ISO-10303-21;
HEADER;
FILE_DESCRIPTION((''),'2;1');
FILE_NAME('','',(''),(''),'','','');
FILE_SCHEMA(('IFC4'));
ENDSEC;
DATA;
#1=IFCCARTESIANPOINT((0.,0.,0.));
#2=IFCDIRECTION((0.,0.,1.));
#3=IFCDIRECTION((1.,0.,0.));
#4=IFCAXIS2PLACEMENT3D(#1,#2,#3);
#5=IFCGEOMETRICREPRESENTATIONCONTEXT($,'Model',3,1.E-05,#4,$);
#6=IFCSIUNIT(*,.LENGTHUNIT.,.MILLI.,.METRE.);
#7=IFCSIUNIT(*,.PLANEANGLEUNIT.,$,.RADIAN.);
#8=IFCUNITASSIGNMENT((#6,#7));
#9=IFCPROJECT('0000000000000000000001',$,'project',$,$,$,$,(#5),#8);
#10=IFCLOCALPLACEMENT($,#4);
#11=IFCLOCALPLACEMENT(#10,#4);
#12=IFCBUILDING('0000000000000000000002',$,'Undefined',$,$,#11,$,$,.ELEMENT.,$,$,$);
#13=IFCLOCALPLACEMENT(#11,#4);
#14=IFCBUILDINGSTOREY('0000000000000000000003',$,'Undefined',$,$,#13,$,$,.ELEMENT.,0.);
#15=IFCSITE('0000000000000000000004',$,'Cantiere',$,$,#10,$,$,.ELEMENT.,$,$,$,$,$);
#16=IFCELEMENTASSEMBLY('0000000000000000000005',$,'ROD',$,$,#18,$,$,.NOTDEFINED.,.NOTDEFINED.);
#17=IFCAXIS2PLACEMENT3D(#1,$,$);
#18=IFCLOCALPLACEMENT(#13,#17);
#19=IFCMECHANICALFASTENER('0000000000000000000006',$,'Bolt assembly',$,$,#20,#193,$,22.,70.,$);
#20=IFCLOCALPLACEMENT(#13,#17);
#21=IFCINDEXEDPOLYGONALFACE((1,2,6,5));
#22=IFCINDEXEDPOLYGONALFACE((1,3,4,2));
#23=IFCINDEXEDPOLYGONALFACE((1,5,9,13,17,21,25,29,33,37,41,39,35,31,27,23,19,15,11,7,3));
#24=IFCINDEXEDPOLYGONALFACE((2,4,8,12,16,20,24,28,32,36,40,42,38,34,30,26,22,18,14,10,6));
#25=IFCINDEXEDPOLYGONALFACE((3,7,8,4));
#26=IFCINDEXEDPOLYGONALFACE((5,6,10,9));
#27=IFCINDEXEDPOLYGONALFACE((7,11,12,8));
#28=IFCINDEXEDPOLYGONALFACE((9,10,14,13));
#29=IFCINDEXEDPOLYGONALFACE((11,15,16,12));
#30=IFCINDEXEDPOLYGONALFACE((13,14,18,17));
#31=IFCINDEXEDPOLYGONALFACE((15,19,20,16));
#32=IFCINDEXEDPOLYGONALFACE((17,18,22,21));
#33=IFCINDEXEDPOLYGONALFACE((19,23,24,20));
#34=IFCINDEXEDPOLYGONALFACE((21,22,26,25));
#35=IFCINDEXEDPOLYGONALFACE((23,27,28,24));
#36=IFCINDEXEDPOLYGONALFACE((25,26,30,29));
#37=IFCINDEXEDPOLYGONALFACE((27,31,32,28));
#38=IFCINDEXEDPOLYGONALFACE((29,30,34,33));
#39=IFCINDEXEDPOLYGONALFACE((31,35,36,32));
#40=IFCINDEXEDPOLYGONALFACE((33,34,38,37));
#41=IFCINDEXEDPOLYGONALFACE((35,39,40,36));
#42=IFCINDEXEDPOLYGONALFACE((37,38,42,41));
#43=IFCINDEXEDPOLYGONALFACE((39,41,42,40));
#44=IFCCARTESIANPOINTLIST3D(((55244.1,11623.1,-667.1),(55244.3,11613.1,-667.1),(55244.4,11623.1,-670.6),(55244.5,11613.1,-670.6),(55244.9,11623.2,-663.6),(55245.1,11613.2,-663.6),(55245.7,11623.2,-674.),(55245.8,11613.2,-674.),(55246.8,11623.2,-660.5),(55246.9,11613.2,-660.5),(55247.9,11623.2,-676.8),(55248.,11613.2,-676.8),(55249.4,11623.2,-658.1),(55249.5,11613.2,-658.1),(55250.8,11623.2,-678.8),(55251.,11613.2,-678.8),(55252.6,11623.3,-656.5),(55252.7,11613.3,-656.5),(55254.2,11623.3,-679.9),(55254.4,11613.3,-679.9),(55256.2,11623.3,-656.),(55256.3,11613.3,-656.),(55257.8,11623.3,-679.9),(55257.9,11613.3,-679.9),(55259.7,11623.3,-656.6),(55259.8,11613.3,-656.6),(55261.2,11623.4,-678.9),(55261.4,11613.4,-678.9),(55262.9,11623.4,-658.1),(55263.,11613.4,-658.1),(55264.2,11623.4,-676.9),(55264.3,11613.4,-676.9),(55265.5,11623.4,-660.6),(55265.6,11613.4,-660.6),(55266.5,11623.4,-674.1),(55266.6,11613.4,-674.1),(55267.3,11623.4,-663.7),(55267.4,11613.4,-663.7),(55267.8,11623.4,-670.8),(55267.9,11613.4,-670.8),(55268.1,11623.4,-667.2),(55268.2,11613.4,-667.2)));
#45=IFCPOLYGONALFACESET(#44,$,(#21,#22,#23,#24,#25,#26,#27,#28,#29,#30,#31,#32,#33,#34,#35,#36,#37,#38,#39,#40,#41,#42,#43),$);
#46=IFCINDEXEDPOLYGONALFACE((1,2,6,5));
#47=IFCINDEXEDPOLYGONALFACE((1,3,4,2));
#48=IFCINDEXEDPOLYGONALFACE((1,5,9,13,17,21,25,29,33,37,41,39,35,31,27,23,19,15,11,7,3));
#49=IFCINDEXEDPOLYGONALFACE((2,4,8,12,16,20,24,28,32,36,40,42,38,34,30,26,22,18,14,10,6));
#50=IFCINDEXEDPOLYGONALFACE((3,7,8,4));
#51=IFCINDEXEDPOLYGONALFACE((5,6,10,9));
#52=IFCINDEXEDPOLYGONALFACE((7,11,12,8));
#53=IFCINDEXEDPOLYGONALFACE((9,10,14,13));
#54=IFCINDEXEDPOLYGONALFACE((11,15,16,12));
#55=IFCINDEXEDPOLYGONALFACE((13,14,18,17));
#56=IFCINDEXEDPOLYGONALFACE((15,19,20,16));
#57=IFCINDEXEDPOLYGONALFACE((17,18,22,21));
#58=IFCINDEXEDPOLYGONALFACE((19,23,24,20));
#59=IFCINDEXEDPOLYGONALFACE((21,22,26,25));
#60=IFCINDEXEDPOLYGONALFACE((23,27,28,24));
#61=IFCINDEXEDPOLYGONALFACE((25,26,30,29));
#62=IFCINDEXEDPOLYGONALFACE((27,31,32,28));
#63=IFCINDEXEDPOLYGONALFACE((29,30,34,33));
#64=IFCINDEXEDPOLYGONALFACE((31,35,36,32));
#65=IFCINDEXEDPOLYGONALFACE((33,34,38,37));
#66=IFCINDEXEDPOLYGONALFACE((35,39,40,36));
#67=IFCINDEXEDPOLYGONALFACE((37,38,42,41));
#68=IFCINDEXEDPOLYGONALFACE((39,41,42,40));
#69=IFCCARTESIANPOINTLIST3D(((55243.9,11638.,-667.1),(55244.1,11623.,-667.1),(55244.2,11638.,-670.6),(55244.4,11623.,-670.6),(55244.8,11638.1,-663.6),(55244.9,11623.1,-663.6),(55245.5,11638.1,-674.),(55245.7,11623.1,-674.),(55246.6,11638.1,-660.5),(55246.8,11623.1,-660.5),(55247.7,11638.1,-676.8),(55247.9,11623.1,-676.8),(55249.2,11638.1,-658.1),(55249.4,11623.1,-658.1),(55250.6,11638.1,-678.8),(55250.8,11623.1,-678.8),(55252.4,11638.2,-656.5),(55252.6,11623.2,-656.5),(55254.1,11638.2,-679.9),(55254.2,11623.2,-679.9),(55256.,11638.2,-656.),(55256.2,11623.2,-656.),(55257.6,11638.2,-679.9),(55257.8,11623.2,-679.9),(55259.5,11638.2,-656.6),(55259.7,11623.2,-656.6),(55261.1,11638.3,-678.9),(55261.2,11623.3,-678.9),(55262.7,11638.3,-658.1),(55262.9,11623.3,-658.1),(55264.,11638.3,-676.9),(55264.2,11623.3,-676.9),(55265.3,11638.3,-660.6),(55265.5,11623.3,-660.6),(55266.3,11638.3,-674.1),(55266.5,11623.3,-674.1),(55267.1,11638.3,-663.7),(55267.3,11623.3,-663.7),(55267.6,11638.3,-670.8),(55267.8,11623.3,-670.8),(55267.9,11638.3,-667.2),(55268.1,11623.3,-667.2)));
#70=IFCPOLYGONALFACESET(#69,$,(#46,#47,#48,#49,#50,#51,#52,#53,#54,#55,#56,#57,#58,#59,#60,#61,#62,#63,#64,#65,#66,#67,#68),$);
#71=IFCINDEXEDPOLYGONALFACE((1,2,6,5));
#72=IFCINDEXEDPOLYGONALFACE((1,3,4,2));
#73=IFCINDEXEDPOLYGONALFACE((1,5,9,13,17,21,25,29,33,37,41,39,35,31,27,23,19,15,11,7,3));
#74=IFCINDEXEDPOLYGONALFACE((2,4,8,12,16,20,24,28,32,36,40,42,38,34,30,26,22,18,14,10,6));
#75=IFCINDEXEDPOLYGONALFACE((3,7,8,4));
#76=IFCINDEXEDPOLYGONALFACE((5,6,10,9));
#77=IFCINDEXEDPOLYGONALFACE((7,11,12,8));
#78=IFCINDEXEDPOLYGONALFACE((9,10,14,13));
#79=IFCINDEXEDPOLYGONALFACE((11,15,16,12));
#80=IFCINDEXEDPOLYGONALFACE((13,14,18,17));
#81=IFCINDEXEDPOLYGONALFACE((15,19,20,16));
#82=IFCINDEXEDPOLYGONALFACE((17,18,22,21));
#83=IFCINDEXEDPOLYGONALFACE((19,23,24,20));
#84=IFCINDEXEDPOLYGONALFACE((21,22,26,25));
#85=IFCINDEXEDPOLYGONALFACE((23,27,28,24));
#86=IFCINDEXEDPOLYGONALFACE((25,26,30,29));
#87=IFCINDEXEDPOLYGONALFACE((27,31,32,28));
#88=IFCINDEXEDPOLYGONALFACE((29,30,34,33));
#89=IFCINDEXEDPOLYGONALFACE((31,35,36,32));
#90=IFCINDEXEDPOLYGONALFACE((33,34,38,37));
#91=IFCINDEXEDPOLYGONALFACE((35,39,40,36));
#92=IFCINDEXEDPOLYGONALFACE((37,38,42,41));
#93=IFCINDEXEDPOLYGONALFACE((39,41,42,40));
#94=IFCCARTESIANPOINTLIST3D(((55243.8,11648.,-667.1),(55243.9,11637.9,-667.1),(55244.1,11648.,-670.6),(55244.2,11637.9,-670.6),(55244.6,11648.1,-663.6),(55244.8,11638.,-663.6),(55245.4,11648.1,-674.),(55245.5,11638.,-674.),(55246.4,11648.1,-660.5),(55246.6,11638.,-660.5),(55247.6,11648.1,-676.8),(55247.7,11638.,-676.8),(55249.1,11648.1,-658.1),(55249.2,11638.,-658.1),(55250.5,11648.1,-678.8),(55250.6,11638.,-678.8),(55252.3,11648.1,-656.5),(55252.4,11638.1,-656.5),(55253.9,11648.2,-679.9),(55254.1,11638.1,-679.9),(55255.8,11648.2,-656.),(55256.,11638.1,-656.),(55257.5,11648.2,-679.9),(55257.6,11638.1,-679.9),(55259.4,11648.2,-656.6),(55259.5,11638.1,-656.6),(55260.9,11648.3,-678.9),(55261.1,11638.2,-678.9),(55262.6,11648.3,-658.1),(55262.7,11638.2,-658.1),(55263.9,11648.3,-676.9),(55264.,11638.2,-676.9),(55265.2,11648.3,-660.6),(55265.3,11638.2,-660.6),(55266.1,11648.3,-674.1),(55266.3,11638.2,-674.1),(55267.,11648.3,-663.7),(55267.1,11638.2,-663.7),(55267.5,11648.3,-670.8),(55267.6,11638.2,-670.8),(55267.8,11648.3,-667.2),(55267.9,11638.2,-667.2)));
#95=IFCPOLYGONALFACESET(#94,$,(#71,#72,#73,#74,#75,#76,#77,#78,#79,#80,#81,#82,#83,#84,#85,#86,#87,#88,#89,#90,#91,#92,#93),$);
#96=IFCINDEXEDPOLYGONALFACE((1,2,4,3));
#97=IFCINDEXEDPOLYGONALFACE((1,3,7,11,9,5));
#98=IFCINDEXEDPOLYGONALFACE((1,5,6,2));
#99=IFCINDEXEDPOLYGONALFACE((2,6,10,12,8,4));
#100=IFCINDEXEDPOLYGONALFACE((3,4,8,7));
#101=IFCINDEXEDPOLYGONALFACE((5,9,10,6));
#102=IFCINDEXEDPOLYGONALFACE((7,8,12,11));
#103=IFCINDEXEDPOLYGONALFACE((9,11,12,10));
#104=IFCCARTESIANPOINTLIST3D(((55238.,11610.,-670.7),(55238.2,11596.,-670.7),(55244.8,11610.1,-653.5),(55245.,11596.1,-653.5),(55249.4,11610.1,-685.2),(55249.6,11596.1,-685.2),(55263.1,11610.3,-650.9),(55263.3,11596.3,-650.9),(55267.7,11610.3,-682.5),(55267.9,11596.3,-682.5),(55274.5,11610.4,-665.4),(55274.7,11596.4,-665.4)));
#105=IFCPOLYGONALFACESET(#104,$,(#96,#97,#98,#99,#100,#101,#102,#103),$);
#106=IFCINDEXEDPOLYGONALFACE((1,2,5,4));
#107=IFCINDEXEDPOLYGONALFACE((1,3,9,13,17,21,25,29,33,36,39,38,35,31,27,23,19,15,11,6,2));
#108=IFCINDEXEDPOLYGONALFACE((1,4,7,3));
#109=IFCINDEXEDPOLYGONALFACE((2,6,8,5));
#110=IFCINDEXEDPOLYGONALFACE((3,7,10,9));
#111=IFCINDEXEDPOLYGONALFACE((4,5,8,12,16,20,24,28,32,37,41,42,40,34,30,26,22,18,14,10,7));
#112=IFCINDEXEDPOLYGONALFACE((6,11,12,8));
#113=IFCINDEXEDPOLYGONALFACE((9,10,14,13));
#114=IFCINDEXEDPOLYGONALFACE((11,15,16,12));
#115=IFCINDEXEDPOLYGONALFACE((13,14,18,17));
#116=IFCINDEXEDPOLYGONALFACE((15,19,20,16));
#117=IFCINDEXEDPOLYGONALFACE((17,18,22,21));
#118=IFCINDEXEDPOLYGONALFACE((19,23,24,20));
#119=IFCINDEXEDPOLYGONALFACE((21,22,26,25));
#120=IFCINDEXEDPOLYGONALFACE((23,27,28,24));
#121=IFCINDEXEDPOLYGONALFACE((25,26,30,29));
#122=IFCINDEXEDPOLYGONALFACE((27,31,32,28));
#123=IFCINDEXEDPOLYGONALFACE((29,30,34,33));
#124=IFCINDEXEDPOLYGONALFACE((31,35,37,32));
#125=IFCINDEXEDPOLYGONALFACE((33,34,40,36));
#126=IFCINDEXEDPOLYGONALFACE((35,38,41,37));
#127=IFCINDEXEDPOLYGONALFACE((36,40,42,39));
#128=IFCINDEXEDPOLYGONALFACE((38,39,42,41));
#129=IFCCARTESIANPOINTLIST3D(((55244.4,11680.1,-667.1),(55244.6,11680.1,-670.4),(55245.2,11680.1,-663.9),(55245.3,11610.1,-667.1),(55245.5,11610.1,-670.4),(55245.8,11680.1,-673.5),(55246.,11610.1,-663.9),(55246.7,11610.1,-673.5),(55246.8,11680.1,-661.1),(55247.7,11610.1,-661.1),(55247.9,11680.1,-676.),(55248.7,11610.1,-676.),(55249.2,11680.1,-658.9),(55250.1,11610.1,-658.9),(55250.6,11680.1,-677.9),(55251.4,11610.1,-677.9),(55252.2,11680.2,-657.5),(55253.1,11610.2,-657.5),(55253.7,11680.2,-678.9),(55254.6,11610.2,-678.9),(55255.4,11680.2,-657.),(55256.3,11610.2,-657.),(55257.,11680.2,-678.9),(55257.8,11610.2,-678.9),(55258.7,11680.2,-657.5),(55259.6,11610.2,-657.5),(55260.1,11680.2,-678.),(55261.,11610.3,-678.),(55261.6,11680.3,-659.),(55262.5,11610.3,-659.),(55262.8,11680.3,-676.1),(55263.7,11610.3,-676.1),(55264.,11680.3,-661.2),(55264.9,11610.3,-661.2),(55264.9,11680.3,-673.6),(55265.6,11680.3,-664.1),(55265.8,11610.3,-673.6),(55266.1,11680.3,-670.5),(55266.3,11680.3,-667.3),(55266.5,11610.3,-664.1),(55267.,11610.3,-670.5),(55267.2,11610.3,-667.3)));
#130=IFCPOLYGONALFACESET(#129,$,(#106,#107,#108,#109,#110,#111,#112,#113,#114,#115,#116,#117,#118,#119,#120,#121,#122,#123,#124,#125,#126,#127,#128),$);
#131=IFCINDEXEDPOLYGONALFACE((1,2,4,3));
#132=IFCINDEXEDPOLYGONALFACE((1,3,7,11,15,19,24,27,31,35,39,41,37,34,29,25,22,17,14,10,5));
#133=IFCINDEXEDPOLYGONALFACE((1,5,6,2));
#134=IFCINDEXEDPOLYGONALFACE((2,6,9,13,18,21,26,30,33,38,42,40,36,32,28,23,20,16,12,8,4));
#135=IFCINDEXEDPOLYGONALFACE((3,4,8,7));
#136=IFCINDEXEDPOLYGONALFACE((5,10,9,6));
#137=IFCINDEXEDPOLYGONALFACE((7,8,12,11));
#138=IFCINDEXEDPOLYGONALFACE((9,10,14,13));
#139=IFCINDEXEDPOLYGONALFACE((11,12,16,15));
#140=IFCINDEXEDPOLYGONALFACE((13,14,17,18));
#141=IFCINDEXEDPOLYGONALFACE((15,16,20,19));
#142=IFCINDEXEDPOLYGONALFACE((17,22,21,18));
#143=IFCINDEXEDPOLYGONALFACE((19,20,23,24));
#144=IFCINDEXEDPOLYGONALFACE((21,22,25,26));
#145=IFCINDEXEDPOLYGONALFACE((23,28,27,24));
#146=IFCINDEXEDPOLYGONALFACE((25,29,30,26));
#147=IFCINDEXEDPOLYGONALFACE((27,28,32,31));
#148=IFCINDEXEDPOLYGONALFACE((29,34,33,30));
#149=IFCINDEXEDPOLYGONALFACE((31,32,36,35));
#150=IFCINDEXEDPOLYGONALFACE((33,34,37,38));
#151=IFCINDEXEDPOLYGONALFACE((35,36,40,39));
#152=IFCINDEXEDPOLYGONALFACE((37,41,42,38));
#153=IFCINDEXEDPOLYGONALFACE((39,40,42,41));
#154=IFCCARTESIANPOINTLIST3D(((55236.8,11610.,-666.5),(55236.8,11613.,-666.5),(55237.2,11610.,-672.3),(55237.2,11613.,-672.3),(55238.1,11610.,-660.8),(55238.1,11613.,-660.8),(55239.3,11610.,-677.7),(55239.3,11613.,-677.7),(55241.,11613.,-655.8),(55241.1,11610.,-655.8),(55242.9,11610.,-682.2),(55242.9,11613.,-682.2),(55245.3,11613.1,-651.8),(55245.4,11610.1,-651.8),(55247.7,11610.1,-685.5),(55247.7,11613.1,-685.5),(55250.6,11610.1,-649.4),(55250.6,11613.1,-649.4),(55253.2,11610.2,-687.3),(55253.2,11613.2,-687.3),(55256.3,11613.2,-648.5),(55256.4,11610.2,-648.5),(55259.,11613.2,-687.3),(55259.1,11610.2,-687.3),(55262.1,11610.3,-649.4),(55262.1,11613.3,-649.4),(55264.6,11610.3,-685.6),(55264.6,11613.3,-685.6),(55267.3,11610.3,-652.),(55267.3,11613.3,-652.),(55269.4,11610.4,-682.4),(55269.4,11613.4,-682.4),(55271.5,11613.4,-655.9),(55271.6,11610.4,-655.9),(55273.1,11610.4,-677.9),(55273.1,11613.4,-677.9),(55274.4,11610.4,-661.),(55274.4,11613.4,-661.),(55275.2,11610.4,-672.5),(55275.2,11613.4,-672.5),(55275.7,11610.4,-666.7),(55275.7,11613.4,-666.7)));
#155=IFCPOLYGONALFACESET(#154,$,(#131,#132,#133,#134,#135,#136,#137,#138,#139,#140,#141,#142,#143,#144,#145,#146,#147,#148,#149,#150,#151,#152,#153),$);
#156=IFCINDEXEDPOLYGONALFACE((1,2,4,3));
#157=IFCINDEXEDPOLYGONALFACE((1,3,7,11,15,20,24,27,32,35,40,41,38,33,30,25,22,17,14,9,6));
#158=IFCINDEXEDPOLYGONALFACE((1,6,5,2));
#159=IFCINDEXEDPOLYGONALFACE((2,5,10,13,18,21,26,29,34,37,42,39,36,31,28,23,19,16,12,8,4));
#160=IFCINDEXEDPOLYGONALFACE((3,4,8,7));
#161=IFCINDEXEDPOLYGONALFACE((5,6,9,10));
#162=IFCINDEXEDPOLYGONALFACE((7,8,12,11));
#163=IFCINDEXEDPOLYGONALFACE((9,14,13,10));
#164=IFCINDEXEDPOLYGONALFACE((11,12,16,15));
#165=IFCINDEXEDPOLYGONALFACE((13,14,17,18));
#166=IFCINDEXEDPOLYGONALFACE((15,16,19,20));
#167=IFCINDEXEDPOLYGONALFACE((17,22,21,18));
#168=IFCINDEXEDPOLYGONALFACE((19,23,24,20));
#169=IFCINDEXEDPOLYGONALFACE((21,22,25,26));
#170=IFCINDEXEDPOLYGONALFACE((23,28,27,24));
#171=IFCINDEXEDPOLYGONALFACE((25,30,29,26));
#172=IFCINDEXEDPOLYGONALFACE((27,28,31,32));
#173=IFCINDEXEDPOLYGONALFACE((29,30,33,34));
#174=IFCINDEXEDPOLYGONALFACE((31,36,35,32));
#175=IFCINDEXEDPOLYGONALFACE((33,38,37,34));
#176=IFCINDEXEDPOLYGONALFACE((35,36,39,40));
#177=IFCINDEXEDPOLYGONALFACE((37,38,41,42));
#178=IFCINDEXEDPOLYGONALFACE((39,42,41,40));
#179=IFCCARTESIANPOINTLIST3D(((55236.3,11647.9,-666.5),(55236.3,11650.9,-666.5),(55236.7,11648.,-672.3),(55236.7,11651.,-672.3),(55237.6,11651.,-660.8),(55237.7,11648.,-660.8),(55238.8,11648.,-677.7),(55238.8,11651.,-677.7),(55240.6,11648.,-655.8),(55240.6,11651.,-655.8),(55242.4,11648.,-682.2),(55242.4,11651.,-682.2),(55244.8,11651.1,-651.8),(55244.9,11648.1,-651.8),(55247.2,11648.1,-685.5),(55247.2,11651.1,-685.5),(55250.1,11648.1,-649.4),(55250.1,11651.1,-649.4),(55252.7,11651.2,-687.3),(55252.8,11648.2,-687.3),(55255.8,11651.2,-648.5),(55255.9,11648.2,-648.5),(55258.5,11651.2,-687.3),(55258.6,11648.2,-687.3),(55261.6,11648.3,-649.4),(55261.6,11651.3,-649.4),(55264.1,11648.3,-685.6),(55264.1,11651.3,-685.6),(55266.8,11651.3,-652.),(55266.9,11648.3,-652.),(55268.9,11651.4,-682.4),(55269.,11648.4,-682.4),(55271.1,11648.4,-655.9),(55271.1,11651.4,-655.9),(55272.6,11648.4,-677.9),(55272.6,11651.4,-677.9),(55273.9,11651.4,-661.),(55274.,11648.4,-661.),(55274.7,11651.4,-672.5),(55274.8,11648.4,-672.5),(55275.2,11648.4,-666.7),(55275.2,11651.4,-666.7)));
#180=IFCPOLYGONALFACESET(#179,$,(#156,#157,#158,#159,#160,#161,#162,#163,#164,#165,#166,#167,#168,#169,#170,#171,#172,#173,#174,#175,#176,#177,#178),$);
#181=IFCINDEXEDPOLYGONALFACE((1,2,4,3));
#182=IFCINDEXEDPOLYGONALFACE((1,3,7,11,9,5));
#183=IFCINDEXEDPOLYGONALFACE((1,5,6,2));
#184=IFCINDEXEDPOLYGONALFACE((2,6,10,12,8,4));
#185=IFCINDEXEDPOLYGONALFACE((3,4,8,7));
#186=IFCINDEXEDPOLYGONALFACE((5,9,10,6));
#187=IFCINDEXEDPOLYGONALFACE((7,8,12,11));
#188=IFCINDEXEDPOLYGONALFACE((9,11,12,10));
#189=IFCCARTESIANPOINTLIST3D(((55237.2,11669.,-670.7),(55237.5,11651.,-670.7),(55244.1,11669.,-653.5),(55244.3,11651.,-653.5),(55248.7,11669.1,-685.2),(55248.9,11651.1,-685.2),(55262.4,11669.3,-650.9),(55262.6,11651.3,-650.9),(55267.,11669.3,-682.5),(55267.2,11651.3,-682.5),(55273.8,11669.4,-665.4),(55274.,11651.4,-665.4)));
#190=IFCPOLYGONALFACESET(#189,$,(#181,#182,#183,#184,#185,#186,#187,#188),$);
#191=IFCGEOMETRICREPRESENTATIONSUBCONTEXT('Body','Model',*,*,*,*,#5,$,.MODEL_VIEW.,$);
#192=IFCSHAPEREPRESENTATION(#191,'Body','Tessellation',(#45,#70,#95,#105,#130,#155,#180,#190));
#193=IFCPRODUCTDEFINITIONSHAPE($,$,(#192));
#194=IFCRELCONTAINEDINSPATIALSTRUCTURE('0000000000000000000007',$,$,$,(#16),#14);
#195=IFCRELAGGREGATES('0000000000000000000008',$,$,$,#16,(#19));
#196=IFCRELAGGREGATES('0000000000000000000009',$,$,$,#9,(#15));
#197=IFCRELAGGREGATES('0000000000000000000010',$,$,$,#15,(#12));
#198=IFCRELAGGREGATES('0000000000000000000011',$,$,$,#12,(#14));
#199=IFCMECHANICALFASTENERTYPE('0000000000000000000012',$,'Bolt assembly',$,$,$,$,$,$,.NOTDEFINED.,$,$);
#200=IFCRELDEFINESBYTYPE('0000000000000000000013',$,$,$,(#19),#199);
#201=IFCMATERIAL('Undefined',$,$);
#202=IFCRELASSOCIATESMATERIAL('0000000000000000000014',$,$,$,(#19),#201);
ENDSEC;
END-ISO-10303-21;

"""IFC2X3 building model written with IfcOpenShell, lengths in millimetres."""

from ifc_helpers import new_model, si_unit, frame, origin_with_axes, origin_2d_with_axis, place, context, subcontext, project, spatial, polyline, circle, outline, extrude, source, transform, mapped, material, type_object, element, aggregate, save


model = new_model("IFC2X3")

# Units and contexts
model_context = context("Model", 3, precision=1e-05, world=origin_with_axes())
body_context = subcontext(model_context, "Body", "Model", "MODEL_VIEW")
ifc_project = project(units=[si_unit("LENGTHUNIT", "METRE", prefix="MILLI"), si_unit("PLANEANGLEUNIT", "RADIAN")], contexts=[model_context])

# Site, building, storey
site_placement = place(None, origin_with_axes())
site = spatial("IfcSite", under=ifc_project, at=site_placement, Name="Cantiere", CompositionType="ELEMENT")
building_placement = place(site_placement, origin_with_axes())
building = spatial("IfcBuilding", under=site, at=building_placement, Name="Undefined", CompositionType="ELEMENT")
storey_placement = place(building_placement, origin_with_axes())
storey = spatial("IfcBuildingStorey", under=building, at=storey_placement, Name="Undefined", CompositionType="ELEMENT", Elevation=0.0)

# Element assembly
assembly_1_placement = place(storey_placement, origin_with_axes())
assembly_1 = element("IfcElementAssembly", 1, at=assembly_1_placement, inside=storey, Name="ROD", AssemblyPlace="NOTDEFINED", PredefinedType="NOTDEFINED")

# Mechanical fastener
ifc_material_1 = material(Name="Undefined")
mechanical_fastener_type = type_object("IfcMechanicalFastenerType", Name="Bolt assembly")
shared_shape_1 = source(origin_with_axes(), body_context, "Body", "SweptSolid", [
    extrude(circle(Radius=12.0, at=origin_2d_with_axis()), frame((0.0, 0.1, 0.0), z_axis=(0.0, 1.0, 0.0), x_axis=(1.0, 0.0, 0.0)), (0.0, 0.0, 1.0), 10.0),
    extrude(circle(Radius=12.0, at=origin_2d_with_axis()), frame((0.0, 10.0, 0.0), z_axis=(0.0, 1.0, 0.0), x_axis=(1.0, 0.0, 0.0)), (0.0, 0.0, 1.0), 15.0),
    extrude(circle(Radius=12.0, at=origin_2d_with_axis()), frame((0.0, 24.9, 0.0), z_axis=(0.0, 1.0, 0.0), x_axis=(1.0, 0.0, 0.0)), (0.0, 0.0, 1.0), 10.1),
    extrude(outline(polyline([(16.0, -9.2), (16.0, 9.2), (0.0, 18.5), (-16.0, 9.2), (-16.0, -9.2), (0.0, -18.5), (16.0, -9.2)])), frame((0.0, -17.0, 0.0), z_axis=(0.0, 1.0, 0.0), x_axis=(1.0, 0.0, 0.0)), (0.0, 0.0, 1.0), 14.0),
    extrude(circle(Radius=11.0, at=origin_2d_with_axis()), frame((0.0, -3.0, 0.0), z_axis=(0.0, 1.0, 0.0), x_axis=(1.0, 0.0, 0.0)), (0.0, 0.0, 1.0), 70.0),
    extrude(circle(Radius=19.5, at=origin_2d_with_axis()), frame((0.0, -3.0, 0.0), z_axis=(0.0, 1.0, 0.0), x_axis=(1.0, 0.0, 0.0)), (0.0, 0.0, 1.0), 3.0),
    extrude(circle(Radius=19.5, at=origin_2d_with_axis()), frame((0.0, 35.0, 0.0), z_axis=(0.0, 1.0, 0.0), x_axis=(1.0, 0.0, 0.0)), (0.0, 0.0, 1.0), 3.0),
    extrude(outline(polyline([(16.0, -9.2), (16.0, 9.2), (0.0, 18.5), (-16.0, 9.2), (-16.0, -9.2), (0.0, -18.5), (16.0, -9.2)])), frame((0.0, 38.0, 0.0), z_axis=(0.0, 1.0, 0.0), x_axis=(1.0, 0.0, 0.0)), (0.0, 0.0, 1.0), 18.0),
])
mechanical_fastener_1_placement = place(assembly_1_placement, frame((55256.2, 11613.2, -668.0), z_axis=(-0.370312, -0.004677, -0.928896), x_axis=(-0.928822, -0.011718, 0.370341)))
mechanical_fastener_1 = element("IfcMechanicalFastener", 2, at=mechanical_fastener_1_placement, type_object=mechanical_fastener_type, material=ifc_material_1, Name="Bolt assembly", NominalDiameter=22.0, NominalLength=70.0, context=body_context, shape_type="MappedRepresentation", body=[
    mapped(shared_shape_1, transform((0.0, 0.0, 0.0))),
])
aggregate(assembly_1, [mechanical_fastener_1])

save(model, "model.ifc")
